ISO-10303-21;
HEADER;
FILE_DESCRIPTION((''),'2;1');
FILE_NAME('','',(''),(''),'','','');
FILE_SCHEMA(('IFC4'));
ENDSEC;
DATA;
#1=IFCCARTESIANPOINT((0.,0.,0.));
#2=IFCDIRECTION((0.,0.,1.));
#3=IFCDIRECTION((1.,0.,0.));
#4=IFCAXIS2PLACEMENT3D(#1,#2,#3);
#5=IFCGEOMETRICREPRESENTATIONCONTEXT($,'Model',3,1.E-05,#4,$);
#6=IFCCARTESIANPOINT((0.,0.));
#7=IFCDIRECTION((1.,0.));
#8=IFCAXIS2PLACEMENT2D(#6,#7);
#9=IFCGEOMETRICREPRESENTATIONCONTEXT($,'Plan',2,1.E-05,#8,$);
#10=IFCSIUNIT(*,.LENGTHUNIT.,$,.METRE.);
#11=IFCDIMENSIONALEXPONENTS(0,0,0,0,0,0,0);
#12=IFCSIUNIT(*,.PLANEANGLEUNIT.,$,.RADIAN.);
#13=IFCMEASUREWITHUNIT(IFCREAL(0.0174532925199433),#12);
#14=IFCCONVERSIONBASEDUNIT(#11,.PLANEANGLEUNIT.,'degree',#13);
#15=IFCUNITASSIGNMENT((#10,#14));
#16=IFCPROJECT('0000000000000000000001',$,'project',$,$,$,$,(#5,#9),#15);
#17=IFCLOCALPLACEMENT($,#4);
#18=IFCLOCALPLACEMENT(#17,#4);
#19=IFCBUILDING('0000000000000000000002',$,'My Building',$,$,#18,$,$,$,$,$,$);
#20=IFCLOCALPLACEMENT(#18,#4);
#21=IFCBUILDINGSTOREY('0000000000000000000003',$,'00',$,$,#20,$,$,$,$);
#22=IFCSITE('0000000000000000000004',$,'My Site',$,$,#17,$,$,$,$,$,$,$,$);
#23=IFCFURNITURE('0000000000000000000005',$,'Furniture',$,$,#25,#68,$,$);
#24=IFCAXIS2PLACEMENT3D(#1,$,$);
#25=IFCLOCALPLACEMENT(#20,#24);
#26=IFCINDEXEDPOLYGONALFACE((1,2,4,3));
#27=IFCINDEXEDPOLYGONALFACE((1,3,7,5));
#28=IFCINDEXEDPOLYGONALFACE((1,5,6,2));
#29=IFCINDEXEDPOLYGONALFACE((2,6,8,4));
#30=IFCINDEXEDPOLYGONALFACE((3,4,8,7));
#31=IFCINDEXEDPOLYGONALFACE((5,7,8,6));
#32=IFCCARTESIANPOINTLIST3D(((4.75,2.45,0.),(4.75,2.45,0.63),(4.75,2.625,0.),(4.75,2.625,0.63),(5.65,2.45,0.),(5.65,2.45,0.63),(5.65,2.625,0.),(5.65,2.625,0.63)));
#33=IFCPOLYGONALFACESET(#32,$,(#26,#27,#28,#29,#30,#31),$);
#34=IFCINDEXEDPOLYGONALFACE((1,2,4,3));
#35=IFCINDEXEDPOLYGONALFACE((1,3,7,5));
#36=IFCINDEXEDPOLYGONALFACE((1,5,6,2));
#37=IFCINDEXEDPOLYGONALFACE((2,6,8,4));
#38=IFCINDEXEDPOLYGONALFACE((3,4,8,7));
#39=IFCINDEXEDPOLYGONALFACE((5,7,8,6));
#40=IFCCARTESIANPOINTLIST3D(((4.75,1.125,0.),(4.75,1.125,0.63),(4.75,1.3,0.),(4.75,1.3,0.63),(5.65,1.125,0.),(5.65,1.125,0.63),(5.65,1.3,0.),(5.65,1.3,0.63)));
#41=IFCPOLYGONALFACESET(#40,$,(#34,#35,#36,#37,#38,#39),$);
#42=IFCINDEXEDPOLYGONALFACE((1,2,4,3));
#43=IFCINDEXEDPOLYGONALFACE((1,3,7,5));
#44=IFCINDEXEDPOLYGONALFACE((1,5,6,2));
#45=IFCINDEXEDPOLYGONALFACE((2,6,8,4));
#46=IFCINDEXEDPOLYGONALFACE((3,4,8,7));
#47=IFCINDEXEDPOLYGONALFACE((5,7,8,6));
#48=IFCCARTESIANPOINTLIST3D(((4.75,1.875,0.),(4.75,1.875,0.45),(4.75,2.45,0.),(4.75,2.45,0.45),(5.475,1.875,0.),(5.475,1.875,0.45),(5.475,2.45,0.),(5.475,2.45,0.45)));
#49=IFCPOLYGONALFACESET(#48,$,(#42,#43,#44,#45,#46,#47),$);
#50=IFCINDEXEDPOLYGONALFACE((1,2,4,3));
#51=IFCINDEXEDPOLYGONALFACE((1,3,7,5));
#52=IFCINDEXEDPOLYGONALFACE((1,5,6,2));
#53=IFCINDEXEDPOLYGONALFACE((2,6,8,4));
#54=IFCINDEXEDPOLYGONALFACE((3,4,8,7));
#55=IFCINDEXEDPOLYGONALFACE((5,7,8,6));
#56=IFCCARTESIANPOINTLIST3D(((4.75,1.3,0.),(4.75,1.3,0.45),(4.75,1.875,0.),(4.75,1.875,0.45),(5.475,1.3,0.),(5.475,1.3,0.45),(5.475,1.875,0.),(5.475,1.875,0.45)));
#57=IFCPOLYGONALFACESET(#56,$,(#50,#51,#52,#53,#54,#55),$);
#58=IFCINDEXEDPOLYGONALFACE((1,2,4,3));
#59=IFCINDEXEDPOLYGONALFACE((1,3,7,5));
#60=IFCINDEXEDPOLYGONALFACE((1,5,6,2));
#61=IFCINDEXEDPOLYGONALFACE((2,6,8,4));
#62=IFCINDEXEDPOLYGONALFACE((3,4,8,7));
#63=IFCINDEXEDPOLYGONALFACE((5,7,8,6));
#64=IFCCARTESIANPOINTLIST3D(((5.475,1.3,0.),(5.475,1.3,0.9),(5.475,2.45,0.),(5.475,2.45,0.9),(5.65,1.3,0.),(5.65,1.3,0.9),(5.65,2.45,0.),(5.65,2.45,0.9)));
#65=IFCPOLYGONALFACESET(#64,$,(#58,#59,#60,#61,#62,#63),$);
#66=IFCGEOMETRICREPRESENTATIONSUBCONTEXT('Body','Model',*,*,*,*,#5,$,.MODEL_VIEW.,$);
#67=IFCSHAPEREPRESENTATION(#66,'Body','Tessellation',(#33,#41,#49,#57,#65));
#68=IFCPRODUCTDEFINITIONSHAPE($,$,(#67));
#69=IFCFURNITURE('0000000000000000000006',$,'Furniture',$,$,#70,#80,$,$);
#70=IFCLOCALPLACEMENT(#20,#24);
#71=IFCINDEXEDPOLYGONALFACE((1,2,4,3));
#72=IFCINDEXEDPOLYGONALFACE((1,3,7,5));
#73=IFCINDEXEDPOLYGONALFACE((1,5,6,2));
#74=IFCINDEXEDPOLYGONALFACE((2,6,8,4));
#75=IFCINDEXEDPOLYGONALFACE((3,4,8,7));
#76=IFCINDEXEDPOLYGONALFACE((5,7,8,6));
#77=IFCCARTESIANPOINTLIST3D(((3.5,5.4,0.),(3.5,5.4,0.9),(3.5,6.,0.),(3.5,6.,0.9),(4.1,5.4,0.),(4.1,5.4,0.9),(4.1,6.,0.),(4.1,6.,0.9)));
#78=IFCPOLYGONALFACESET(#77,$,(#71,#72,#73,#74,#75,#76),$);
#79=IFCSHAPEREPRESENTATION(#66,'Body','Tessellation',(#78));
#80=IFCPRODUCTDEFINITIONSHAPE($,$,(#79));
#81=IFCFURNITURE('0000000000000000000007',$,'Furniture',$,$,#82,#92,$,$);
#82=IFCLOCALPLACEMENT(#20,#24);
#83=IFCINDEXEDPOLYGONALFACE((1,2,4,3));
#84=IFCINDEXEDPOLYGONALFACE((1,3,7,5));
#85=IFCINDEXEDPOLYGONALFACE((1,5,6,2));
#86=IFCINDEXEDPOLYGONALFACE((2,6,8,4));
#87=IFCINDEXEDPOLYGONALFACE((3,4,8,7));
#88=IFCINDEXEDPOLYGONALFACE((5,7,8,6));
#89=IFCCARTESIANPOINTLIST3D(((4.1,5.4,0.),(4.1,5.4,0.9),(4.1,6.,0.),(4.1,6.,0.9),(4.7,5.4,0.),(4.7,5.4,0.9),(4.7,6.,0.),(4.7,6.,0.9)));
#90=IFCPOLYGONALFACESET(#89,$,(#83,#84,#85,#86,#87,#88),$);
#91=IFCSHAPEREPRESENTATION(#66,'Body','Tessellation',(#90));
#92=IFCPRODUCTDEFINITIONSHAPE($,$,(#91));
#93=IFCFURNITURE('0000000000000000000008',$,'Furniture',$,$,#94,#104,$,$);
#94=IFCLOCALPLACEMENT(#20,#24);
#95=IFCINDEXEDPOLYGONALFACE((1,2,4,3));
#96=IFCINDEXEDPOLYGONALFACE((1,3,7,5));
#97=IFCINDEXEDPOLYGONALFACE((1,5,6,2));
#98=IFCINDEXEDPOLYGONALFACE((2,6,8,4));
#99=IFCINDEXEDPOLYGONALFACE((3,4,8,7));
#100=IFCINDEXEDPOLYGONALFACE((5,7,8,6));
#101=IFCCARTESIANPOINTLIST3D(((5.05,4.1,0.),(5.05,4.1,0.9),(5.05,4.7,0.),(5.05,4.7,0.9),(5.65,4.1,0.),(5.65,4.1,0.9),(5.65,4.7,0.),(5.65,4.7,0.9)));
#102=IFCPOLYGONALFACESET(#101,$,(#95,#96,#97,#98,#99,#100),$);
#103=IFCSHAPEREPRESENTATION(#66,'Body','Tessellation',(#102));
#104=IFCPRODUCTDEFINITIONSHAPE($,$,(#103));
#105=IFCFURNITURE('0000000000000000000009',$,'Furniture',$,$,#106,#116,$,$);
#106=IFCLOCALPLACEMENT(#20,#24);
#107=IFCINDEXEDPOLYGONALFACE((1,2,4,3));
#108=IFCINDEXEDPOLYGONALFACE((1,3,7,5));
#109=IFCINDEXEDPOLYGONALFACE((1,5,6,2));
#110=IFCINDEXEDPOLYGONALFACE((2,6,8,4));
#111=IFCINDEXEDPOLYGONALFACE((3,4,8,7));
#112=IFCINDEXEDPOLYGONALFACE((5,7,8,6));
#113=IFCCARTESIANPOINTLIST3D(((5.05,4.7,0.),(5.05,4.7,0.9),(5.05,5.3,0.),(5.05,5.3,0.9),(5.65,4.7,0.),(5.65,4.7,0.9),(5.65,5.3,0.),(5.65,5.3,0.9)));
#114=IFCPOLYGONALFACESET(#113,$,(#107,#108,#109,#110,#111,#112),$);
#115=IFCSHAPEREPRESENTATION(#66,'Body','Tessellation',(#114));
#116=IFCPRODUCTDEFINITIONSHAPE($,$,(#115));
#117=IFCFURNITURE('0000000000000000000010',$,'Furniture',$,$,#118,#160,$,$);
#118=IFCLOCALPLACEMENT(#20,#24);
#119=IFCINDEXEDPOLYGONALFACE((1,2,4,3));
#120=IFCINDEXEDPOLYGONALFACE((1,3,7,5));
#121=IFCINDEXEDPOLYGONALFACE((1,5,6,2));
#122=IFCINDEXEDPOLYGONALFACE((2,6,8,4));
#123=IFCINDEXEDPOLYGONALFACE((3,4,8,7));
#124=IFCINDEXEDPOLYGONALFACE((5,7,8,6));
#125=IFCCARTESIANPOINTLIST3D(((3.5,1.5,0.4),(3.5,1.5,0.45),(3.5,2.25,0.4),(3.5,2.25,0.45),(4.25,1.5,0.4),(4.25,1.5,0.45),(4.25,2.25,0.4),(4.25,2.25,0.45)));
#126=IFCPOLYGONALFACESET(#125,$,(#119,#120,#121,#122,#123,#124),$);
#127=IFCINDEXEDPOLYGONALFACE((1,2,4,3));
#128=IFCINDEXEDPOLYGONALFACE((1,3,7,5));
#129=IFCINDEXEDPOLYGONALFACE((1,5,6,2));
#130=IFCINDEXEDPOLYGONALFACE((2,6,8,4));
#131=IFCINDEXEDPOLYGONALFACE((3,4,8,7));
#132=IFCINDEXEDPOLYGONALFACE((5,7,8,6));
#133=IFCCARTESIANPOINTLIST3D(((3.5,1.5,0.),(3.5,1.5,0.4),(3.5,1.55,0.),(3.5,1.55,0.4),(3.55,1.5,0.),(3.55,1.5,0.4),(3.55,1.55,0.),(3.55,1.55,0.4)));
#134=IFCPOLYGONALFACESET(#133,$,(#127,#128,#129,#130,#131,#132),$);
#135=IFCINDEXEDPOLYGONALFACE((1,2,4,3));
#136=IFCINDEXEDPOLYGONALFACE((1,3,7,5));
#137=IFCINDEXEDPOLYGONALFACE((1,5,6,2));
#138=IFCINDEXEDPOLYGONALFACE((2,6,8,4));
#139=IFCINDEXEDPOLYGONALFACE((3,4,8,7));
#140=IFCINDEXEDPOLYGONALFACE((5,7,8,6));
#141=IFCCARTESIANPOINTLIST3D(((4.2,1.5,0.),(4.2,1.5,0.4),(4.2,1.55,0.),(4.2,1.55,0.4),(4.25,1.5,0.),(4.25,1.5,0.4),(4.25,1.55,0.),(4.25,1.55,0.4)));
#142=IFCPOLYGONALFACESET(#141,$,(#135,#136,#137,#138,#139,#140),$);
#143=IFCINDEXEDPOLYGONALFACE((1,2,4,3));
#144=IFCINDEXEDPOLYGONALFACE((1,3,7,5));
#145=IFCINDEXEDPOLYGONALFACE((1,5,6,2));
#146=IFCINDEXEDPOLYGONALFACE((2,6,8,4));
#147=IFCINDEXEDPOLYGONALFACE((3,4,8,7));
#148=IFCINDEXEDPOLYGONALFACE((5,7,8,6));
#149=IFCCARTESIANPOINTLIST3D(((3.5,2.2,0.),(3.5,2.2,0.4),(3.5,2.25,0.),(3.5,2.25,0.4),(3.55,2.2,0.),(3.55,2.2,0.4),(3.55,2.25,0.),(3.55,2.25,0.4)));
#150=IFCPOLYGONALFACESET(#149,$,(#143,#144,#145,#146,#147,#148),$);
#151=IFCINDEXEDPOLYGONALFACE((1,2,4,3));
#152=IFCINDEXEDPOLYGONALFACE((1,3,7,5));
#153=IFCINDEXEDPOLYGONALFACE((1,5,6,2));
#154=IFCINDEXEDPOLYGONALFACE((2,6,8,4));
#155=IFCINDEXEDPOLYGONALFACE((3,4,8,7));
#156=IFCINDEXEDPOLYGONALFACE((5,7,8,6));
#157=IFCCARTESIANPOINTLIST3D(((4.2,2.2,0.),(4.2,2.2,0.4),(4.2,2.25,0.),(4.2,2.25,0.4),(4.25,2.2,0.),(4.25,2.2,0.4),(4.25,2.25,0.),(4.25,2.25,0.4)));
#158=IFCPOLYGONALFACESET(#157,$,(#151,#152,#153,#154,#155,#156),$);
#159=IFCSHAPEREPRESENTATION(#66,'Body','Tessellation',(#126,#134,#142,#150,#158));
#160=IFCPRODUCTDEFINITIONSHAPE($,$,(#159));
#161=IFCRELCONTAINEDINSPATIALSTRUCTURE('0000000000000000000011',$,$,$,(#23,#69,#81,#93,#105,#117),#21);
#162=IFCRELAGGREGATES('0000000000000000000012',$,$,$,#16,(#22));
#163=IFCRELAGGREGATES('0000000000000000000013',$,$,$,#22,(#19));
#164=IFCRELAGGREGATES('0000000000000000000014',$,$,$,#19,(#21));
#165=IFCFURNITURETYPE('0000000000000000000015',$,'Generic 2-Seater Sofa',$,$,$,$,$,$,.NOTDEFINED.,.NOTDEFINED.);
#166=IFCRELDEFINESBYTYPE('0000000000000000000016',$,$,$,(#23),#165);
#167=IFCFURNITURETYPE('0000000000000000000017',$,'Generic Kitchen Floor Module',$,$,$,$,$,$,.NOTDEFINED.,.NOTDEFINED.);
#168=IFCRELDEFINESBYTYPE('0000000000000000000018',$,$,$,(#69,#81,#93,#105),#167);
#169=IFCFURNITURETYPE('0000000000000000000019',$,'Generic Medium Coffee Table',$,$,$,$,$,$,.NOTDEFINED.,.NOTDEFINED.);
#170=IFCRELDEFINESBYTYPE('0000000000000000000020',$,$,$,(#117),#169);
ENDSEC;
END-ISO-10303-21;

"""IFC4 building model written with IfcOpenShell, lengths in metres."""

from ifc_helpers import new_model, entity, si_unit, converted_unit, frame, origin_with_axes, origin_2d_with_axis, place, context, subcontext, project, spatial, line, indexed_curve, outline, extrude, shape, source, transform, mapped, type_object, type_shapes, element, save


model = new_model("IFC4")

# Units and contexts
model_context = context("Model", 3, precision=1e-05, world=origin_with_axes())
plan_context = context("Plan", 2, precision=1e-05, world=origin_2d_with_axis())
body_context_1 = subcontext(model_context, "Body", "Model", "MODEL_VIEW")
body_context_2 = subcontext(plan_context, "Body", "Plan", "PLAN_VIEW")
ifc_project = project(units=[si_unit("LENGTHUNIT", "METRE"), converted_unit("PLANEANGLEUNIT", "degree", entity("IfcReal", 0.0174532925199433), si_unit("PLANEANGLEUNIT", "RADIAN"), dimensions=[0, 0, 0, 0, 0, 0, 0])], contexts=[model_context, plan_context])

# Site, building, storey
site_placement = place(None, origin_with_axes())
site = spatial("IfcSite", under=ifc_project, at=site_placement, Name="My Site")
building_placement = place(site_placement, origin_with_axes())
building = spatial("IfcBuilding", under=site, at=building_placement, Name="My Building")
storey_placement = place(building_placement, origin_with_axes())
storey = spatial("IfcBuildingStorey", under=building, at=storey_placement, Name="00")

# Furniture
furniture_type_1 = type_object("IfcFurnitureType", Name="Generic 2-Seater Sofa", AssemblyPlace="NOTDEFINED", PredefinedType="NOTDEFINED")
shared_shape_1 = source(origin_with_axes(), body_context_1, "Body", "SweptSolid", [
    extrude(outline(indexed_curve([(0.0, 0.0), (0.175, 0.0), (0.175, 0.9), (0.0, 0.9)], segments=[line(1, 2, 3, 4, 1)])), frame((-0.75, -0.9, 0.0), z_axis=(0.0, 0.0, 1.0), x_axis=(1.0, 0.0, 0.0)), (0.0, 0.0, 1.0), 0.63),
    extrude(outline(indexed_curve([(0.0, 0.0), (0.175, 0.0), (0.175, 0.9), (0.0, 0.9)], segments=[line(1, 2, 3, 4, 1)])), frame((0.575, -0.9, 0.0), z_axis=(0.0, 0.0, 1.0), x_axis=(1.0, 0.0, 0.0)), (0.0, 0.0, 1.0), 0.63),
    extrude(outline(indexed_curve([(0.175, 0.0), (0.75, 0.0), (0.75, 0.725), (0.175, 0.725)], segments=[line(1, 2, 3, 4, 1)])), frame((-0.75, -0.9, 0.0), z_axis=(0.0, 0.0, 1.0), x_axis=(1.0, 0.0, 0.0)), (0.0, 0.0, 1.0), 0.45),
    extrude(outline(indexed_curve([(0.75, 0.0), (1.325, 0.0), (1.325, 0.725), (0.75, 0.725)], segments=[line(1, 2, 3, 4, 1)])), frame((-0.75, -0.9, 0.0), z_axis=(0.0, 0.0, 1.0), x_axis=(1.0, 0.0, 0.0)), (0.0, 0.0, 1.0), 0.45),
    extrude(outline(indexed_curve([(0.175, 0.725), (1.325, 0.725), (1.325, 0.9), (0.175, 0.9)], segments=[line(1, 2, 3, 4, 1)])), frame((-0.75, -0.9, 0.0), z_axis=(0.0, 0.0, 1.0), x_axis=(1.0, 0.0, 0.0)), (0.0, 0.0, 1.0), 0.9),
])
shared_shape_2 = source(origin_with_axes(), body_context_2, "Body", "Curve2D", [
    entity("IfcIndexedPolyCurve", entity("IfcCartesianPointList2D", [[-0.75, -0.9], [-0.575, -0.9], [-0.575, 0.0], [-0.75, 0.0]]), [entity("IfcLineIndex", [1, 2, 3, 4, 1])]),
    entity("IfcIndexedPolyCurve", entity("IfcCartesianPointList2D", [[0.575, -0.9], [0.75, -0.9], [0.75, 0.0], [0.575, 0.0]]), [entity("IfcLineIndex", [1, 2, 3, 4, 1])]),
    entity("IfcIndexedPolyCurve", entity("IfcCartesianPointList2D", [[-0.575, -0.9], [0.0, -0.9], [0.0, -0.175], [-0.575, -0.175]]), [entity("IfcLineIndex", [1, 2, 3, 4, 1])]),
    entity("IfcIndexedPolyCurve", entity("IfcCartesianPointList2D", [[0.0, -0.9], [0.575, -0.9], [0.575, -0.175], [0.0, -0.175]]), [entity("IfcLineIndex", [1, 2, 3, 4, 1])]),
    entity("IfcIndexedPolyCurve", entity("IfcCartesianPointList2D", [[-0.575, -0.175], [0.575, -0.175], [0.575, 0.0], [-0.575, 0.0]]), [entity("IfcLineIndex", [1, 2, 3, 4, 1])]),
])
type_shapes(furniture_type_1, [shared_shape_1, shared_shape_2])
furniture_1_placement = place(storey_placement, frame((5.65, 1.875, 0.0), z_axis=(0.0, 0.0, 1.0), x_axis=(0.0, -1.0, 0.0)))
element("IfcFurniture", 1, at=furniture_1_placement, inside=storey, type_object=furniture_type_1, Name="Furniture", shapes=[
    shape(body_context_1, "Body", "MappedRepresentation", [mapped(shared_shape_1, transform((0.0, 0.0, 0.0), x_axis=(1.0, 0.0, 0.0), y_axis=(0.0, 1.0, 0.0), z_axis=(0.0, 0.0, 1.0), scale=1.0))]),
    shape(body_context_2, "Body", "MappedRepresentation", [mapped(shared_shape_2, transform((0.0, 0.0, 0.0), x_axis=(1.0, 0.0, 0.0), y_axis=(0.0, 1.0, 0.0), z_axis=(0.0, 0.0, 1.0), scale=1.0))]),
])
furniture_type_2 = type_object("IfcFurnitureType", Name="Generic Kitchen Floor Module", AssemblyPlace="NOTDEFINED", PredefinedType="NOTDEFINED")
shared_shape_3 = source(origin_with_axes(), body_context_1, "Body", "SweptSolid", [
    extrude(outline(indexed_curve([(0.0, 0.0), (0.6, 0.0), (0.6, 0.6), (0.0, 0.6)], segments=[line(3, 2), line(2, 1), line(1, 4), line(4, 3)], self_intersect=False)), origin_with_axes(), (0.0, 0.0, 1.0), 0.9),
])
shared_shape_4 = source(origin_with_axes(), body_context_2, "Body", "Annotation2D", [
    entity("IfcGeometricCurveSet", [entity("IfcIndexedPolyCurve", entity("IfcCartesianPointList2D", [[0.0, 0.0], [0.6, 0.0], [0.6, 0.6], [0.0, 0.6]]), [entity("IfcLineIndex", [1, 2]), entity("IfcLineIndex", [2, 3]), entity("IfcLineIndex", [3, 4]), entity("IfcLineIndex", [4, 1])])]),
])
type_shapes(furniture_type_2, [shared_shape_3, shared_shape_4])
for number, where, z_axis, x_axis, name in (
    (2, (3.5, 5.4, 0.0), (0.0, 0.0, 1.0), (1.0, 0.0, 0.0), "Furniture"),
    (3, (4.1, 5.4, 0.0), (0.0, 0.0, 1.0), (1.0, 0.0, 0.0), "Furniture"),
    (4, (5.05, 4.1, 0.0), (0.0, 0.0, 1.0), (1.0, 0.0, 0.0), "Furniture"),
    (5, (5.05, 4.7, 0.0), (0.0, 0.0, 1.0), (1.0, 0.0, 0.0), "Furniture"),
):
    element("IfcFurniture", number, at=place(storey_placement, frame(where, z_axis=z_axis, x_axis=x_axis)), inside=storey, type_object=furniture_type_2, Name=name, shapes=[
        shape(body_context_1, "Body", "MappedRepresentation", [mapped(shared_shape_3, transform((0.0, 0.0, 0.0), x_axis=(1.0, 0.0, 0.0), y_axis=(0.0, 1.0, 0.0), z_axis=(0.0, 0.0, 1.0), scale=1.0))]),
        shape(body_context_2, "Body", "MappedRepresentation", [mapped(shared_shape_4, transform((0.0, 0.0, 0.0), x_axis=(1.0, 0.0, 0.0), y_axis=(0.0, 1.0, 0.0), z_axis=(0.0, 0.0, 1.0), scale=1.0))]),
    ])
furniture_type_3 = type_object("IfcFurnitureType", Name="Generic Medium Coffee Table", AssemblyPlace="NOTDEFINED", PredefinedType="NOTDEFINED")
shared_shape_5 = source(origin_with_axes(), body_context_1, "Body", "SweptSolid", [
    extrude(outline(indexed_curve([(0.0, 0.0), (0.75, 0.0), (0.75, 0.75), (0.0, 0.75)], segments=[line(1, 2, 3, 4, 1)])), frame((-0.375, -0.375, 0.4), z_axis=(0.0, 0.0, 1.0), x_axis=(1.0, 0.0, 0.0)), (0.0, 0.0, 1.0), 0.05),
    extrude(outline(indexed_curve([(0.0, 0.0), (0.05, 0.0), (0.05, 0.05), (0.0, 0.05)], segments=[line(1, 2, 3, 4, 1)])), frame((-0.375, -0.375, 0.0), z_axis=(0.0, 0.0, 1.0), x_axis=(1.0, 0.0, 0.0)), (0.0, 0.0, 1.0), 0.4),
    extrude(outline(indexed_curve([(0.75, 0.0), (0.7, 0.0), (0.7, 0.05), (0.75, 0.05)], segments=[line(1, 2, 3, 4, 1)])), frame((-0.375, -0.375, 0.0), z_axis=(0.0, 0.0, 1.0), x_axis=(1.0, 0.0, 0.0)), (0.0, 0.0, 1.0), 0.4),
    extrude(outline(indexed_curve([(0.0, 0.75), (0.05, 0.75), (0.05, 0.7), (0.0, 0.7)], segments=[line(1, 2, 3, 4, 1)])), frame((-0.375, -0.375, 0.0), z_axis=(0.0, 0.0, 1.0), x_axis=(1.0, 0.0, 0.0)), (0.0, 0.0, 1.0), 0.4),
    extrude(outline(indexed_curve([(0.75, 0.75), (0.7, 0.75), (0.7, 0.7), (0.75, 0.7)], segments=[line(1, 2, 3, 4, 1)])), frame((-0.375, -0.375, 0.0), z_axis=(0.0, 0.0, 1.0), x_axis=(1.0, 0.0, 0.0)), (0.0, 0.0, 1.0), 0.4),
])
shared_shape_6 = source(origin_with_axes(), body_context_2, "Body", "Curve2D", [
    entity("IfcIndexedPolyCurve", entity("IfcCartesianPointList2D", [[-0.375, -0.375], [0.375, -0.375], [0.375, 0.375], [-0.375, 0.375]]), [entity("IfcLineIndex", [1, 2, 3, 4, 1])]),
])
type_shapes(furniture_type_3, [shared_shape_5, shared_shape_6])
furniture_2_placement = place(storey_placement, frame((3.875, 1.875, 0.0), z_axis=(0.0, 0.0, 1.0), x_axis=(1.0, 0.0, 0.0)))
element("IfcFurniture", 6, at=furniture_2_placement, inside=storey, type_object=furniture_type_3, Name="Furniture", shapes=[
    shape(body_context_1, "Body", "MappedRepresentation", [mapped(shared_shape_5, transform((0.0, 0.0, 0.0), x_axis=(1.0, 0.0, 0.0), y_axis=(0.0, 1.0, 0.0), z_axis=(0.0, 0.0, 1.0), scale=1.0))]),
    shape(body_context_2, "Body", "MappedRepresentation", [mapped(shared_shape_6, transform((0.0, 0.0, 0.0), x_axis=(1.0, 0.0, 0.0), y_axis=(0.0, 1.0, 0.0), z_axis=(0.0, 0.0, 1.0), scale=1.0))]),
])

save(model, "model.ifc")
